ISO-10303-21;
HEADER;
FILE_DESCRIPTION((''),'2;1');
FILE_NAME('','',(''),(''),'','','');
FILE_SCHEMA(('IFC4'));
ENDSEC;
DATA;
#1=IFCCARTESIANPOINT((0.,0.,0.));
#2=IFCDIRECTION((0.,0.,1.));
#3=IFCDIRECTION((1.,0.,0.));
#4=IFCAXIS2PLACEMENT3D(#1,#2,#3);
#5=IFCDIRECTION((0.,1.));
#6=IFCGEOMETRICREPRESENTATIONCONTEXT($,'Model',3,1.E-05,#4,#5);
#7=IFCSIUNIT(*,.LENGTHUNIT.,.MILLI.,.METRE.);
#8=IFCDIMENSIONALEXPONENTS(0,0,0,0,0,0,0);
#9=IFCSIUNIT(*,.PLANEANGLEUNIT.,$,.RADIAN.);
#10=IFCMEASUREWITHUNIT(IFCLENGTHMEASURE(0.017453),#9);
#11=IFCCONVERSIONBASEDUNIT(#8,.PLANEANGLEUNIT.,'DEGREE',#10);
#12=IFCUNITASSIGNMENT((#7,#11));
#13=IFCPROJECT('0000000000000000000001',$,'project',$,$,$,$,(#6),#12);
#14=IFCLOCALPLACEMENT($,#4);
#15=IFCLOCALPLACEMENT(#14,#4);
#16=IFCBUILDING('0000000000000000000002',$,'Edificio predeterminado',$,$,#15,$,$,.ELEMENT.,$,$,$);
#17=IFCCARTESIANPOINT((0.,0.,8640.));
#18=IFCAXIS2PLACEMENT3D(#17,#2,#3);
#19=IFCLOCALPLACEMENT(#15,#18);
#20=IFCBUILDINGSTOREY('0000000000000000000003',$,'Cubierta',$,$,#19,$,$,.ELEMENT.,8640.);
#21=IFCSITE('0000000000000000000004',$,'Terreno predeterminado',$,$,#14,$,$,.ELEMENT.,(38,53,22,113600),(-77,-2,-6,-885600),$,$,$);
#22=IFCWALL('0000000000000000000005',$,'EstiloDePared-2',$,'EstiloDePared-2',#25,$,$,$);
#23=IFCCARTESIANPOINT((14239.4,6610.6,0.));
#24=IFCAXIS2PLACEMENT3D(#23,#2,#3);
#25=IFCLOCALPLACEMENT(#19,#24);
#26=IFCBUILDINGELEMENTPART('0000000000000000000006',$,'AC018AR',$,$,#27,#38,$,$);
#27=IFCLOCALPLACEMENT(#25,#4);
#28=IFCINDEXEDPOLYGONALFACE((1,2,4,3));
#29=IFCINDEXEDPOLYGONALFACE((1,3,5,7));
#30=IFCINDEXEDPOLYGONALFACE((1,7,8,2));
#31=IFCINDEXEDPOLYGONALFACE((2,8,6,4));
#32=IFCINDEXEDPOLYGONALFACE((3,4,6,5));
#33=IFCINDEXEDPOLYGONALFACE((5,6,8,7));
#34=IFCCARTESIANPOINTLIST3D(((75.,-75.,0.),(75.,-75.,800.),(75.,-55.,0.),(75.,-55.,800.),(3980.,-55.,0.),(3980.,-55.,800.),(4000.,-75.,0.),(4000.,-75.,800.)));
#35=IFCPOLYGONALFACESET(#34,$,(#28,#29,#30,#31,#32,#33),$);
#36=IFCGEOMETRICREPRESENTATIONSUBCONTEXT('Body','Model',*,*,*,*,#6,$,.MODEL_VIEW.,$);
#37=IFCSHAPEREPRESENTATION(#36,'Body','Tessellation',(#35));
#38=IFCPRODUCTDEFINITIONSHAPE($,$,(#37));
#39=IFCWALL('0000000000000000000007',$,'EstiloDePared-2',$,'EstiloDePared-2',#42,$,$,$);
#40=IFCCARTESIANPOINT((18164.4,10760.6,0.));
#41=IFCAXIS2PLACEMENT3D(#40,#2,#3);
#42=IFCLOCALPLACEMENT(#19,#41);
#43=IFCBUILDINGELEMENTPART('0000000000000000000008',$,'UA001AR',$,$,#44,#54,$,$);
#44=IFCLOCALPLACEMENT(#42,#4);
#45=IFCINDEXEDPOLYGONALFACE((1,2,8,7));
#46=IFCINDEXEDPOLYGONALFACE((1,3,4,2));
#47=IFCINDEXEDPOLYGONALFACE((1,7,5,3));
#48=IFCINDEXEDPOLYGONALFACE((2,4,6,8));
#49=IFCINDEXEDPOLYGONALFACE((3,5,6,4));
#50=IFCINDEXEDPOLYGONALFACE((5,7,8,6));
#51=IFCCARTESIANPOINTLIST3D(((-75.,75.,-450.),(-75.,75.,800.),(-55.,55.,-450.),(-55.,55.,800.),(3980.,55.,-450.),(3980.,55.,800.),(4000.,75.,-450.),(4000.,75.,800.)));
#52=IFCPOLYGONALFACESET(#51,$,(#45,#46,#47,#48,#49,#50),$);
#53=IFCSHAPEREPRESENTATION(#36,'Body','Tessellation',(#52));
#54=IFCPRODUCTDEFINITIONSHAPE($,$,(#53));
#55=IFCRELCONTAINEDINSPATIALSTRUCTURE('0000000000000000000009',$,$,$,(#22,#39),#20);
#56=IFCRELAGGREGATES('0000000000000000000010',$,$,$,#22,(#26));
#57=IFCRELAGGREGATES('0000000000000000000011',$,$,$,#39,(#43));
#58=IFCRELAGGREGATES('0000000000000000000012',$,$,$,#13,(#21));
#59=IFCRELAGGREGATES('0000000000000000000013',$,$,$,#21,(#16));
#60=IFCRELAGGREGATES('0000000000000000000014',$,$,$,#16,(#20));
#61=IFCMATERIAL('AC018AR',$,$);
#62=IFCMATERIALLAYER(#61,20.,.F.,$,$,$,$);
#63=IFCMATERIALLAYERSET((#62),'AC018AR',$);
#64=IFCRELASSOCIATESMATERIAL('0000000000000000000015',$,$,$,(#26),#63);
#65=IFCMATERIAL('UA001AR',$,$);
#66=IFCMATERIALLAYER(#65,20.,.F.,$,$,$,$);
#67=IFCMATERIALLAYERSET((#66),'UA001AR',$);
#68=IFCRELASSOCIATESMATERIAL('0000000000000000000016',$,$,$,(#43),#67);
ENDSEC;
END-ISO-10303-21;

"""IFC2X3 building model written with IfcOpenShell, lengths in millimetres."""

from ifc_helpers import new_model, entity, si_unit, converted_unit, direction, frame, origin_with_axes, place, context, subcontext, project, spatial, polyline, outline, extrude, material, layer, layer_set, layer_usage, element, aggregate, save


model = new_model("IFC2X3")

# Units and contexts
model_context = context("Model", 3, precision=1e-05, world=origin_with_axes(), true_north=direction((0.0, 1.0)))
body_context = subcontext(model_context, "Body", "Model", "MODEL_VIEW")
ifc_project = project(units=[si_unit("LENGTHUNIT", "METRE", prefix="MILLI"), converted_unit("PLANEANGLEUNIT", "DEGREE", entity("IfcLengthMeasure", 0.017453), si_unit("PLANEANGLEUNIT", "RADIAN"), dimensions=[0, 0, 0, 0, 0, 0, 0])], contexts=[model_context])

# Site, building, storey
site_placement = place(None, origin_with_axes())
site = spatial("IfcSite", under=ifc_project, at=site_placement, Name="Terreno predeterminado", CompositionType="ELEMENT", RefLatitude=(38, 53, 22, 113600), RefLongitude=(-77, -2, -6, -885600))
building_placement = place(site_placement, origin_with_axes())
building = spatial("IfcBuilding", under=site, at=building_placement, Name="Edificio predeterminado", CompositionType="ELEMENT")
storey_placement = place(building_placement, frame((0.0, 0.0, 8640.0), z_axis=(0.0, 0.0, 1.0), x_axis=(1.0, 0.0, 0.0)))
storey = spatial("IfcBuildingStorey", under=building, at=storey_placement, Name="Cubierta", CompositionType="ELEMENT", Elevation=8640.0)

# Walls, building element parts
wall_1_placement = place(storey_placement, frame((14239.4, 6610.6, 0.0), z_axis=(0.0, 0.0, 1.0), x_axis=(1.0, 0.0, 0.0)))
wall_1 = element("IfcWall", 1, at=wall_1_placement, inside=storey, Name="EstiloDePared-2", ObjectType="EstiloDePared-2")
ifc_material_1 = material(Name="AC018AR")
ifc_layer_1 = layer(ifc_material_1, 20.0, ventilated=False)
ifc_layer_set_1 = layer_set([ifc_layer_1], Name="AC018AR")
ifc_layer_usage_1 = layer_usage(ifc_layer_set_1, "AXIS2", "NEGATIVE", 55.0)
building_element_part_1_placement = place(wall_1_placement, origin_with_axes())
building_element_part_1 = element("IfcBuildingElementPart", 2, at=building_element_part_1_placement, material=ifc_layer_usage_1, Name="AC018AR", context=body_context, shape_type="SweptSolid", body=[
    extrude(outline(polyline([(3980.0, -55.0), (4000.0, -75.0), (75.0, -75.0), (75.0, -55.0), (3980.0, -55.0)])), origin_with_axes(), (0.0, 0.0, 1.0), 800.0),
])
aggregate(wall_1, [building_element_part_1])
wall_2_placement = place(storey_placement, frame((18164.4, 10760.6, 0.0), z_axis=(0.0, 0.0, 1.0), x_axis=(1.0, 0.0, 0.0)))
wall_2 = element("IfcWall", 3, at=wall_2_placement, inside=storey, Name="EstiloDePared-2", ObjectType="EstiloDePared-2")
ifc_material_2 = material(Name="UA001AR")
ifc_layer_2 = layer(ifc_material_2, 20.0, ventilated=False)
ifc_layer_set_2 = layer_set([ifc_layer_2], Name="UA001AR")
ifc_layer_usage_2 = layer_usage(ifc_layer_set_2, "AXIS2", "NEGATIVE", -75.0)
building_element_part_2_placement = place(wall_2_placement, origin_with_axes())
building_element_part_2 = element("IfcBuildingElementPart", 4, at=building_element_part_2_placement, material=ifc_layer_usage_2, Name="UA001AR", context=body_context, shape_type="SweptSolid", body=[
    extrude(outline(polyline([(4000.0, 75.0), (3980.0, 55.0), (-55.0, 55.0), (-75.0, 75.0), (4000.0, 75.0)])), frame((0.0, 0.0, -450.0), z_axis=(0.0, 0.0, 1.0), x_axis=(1.0, 0.0, 0.0)), (0.0, 0.0, 1.0), 1250.0),
])
aggregate(wall_2, [building_element_part_2])

save(model, "model.ifc")
